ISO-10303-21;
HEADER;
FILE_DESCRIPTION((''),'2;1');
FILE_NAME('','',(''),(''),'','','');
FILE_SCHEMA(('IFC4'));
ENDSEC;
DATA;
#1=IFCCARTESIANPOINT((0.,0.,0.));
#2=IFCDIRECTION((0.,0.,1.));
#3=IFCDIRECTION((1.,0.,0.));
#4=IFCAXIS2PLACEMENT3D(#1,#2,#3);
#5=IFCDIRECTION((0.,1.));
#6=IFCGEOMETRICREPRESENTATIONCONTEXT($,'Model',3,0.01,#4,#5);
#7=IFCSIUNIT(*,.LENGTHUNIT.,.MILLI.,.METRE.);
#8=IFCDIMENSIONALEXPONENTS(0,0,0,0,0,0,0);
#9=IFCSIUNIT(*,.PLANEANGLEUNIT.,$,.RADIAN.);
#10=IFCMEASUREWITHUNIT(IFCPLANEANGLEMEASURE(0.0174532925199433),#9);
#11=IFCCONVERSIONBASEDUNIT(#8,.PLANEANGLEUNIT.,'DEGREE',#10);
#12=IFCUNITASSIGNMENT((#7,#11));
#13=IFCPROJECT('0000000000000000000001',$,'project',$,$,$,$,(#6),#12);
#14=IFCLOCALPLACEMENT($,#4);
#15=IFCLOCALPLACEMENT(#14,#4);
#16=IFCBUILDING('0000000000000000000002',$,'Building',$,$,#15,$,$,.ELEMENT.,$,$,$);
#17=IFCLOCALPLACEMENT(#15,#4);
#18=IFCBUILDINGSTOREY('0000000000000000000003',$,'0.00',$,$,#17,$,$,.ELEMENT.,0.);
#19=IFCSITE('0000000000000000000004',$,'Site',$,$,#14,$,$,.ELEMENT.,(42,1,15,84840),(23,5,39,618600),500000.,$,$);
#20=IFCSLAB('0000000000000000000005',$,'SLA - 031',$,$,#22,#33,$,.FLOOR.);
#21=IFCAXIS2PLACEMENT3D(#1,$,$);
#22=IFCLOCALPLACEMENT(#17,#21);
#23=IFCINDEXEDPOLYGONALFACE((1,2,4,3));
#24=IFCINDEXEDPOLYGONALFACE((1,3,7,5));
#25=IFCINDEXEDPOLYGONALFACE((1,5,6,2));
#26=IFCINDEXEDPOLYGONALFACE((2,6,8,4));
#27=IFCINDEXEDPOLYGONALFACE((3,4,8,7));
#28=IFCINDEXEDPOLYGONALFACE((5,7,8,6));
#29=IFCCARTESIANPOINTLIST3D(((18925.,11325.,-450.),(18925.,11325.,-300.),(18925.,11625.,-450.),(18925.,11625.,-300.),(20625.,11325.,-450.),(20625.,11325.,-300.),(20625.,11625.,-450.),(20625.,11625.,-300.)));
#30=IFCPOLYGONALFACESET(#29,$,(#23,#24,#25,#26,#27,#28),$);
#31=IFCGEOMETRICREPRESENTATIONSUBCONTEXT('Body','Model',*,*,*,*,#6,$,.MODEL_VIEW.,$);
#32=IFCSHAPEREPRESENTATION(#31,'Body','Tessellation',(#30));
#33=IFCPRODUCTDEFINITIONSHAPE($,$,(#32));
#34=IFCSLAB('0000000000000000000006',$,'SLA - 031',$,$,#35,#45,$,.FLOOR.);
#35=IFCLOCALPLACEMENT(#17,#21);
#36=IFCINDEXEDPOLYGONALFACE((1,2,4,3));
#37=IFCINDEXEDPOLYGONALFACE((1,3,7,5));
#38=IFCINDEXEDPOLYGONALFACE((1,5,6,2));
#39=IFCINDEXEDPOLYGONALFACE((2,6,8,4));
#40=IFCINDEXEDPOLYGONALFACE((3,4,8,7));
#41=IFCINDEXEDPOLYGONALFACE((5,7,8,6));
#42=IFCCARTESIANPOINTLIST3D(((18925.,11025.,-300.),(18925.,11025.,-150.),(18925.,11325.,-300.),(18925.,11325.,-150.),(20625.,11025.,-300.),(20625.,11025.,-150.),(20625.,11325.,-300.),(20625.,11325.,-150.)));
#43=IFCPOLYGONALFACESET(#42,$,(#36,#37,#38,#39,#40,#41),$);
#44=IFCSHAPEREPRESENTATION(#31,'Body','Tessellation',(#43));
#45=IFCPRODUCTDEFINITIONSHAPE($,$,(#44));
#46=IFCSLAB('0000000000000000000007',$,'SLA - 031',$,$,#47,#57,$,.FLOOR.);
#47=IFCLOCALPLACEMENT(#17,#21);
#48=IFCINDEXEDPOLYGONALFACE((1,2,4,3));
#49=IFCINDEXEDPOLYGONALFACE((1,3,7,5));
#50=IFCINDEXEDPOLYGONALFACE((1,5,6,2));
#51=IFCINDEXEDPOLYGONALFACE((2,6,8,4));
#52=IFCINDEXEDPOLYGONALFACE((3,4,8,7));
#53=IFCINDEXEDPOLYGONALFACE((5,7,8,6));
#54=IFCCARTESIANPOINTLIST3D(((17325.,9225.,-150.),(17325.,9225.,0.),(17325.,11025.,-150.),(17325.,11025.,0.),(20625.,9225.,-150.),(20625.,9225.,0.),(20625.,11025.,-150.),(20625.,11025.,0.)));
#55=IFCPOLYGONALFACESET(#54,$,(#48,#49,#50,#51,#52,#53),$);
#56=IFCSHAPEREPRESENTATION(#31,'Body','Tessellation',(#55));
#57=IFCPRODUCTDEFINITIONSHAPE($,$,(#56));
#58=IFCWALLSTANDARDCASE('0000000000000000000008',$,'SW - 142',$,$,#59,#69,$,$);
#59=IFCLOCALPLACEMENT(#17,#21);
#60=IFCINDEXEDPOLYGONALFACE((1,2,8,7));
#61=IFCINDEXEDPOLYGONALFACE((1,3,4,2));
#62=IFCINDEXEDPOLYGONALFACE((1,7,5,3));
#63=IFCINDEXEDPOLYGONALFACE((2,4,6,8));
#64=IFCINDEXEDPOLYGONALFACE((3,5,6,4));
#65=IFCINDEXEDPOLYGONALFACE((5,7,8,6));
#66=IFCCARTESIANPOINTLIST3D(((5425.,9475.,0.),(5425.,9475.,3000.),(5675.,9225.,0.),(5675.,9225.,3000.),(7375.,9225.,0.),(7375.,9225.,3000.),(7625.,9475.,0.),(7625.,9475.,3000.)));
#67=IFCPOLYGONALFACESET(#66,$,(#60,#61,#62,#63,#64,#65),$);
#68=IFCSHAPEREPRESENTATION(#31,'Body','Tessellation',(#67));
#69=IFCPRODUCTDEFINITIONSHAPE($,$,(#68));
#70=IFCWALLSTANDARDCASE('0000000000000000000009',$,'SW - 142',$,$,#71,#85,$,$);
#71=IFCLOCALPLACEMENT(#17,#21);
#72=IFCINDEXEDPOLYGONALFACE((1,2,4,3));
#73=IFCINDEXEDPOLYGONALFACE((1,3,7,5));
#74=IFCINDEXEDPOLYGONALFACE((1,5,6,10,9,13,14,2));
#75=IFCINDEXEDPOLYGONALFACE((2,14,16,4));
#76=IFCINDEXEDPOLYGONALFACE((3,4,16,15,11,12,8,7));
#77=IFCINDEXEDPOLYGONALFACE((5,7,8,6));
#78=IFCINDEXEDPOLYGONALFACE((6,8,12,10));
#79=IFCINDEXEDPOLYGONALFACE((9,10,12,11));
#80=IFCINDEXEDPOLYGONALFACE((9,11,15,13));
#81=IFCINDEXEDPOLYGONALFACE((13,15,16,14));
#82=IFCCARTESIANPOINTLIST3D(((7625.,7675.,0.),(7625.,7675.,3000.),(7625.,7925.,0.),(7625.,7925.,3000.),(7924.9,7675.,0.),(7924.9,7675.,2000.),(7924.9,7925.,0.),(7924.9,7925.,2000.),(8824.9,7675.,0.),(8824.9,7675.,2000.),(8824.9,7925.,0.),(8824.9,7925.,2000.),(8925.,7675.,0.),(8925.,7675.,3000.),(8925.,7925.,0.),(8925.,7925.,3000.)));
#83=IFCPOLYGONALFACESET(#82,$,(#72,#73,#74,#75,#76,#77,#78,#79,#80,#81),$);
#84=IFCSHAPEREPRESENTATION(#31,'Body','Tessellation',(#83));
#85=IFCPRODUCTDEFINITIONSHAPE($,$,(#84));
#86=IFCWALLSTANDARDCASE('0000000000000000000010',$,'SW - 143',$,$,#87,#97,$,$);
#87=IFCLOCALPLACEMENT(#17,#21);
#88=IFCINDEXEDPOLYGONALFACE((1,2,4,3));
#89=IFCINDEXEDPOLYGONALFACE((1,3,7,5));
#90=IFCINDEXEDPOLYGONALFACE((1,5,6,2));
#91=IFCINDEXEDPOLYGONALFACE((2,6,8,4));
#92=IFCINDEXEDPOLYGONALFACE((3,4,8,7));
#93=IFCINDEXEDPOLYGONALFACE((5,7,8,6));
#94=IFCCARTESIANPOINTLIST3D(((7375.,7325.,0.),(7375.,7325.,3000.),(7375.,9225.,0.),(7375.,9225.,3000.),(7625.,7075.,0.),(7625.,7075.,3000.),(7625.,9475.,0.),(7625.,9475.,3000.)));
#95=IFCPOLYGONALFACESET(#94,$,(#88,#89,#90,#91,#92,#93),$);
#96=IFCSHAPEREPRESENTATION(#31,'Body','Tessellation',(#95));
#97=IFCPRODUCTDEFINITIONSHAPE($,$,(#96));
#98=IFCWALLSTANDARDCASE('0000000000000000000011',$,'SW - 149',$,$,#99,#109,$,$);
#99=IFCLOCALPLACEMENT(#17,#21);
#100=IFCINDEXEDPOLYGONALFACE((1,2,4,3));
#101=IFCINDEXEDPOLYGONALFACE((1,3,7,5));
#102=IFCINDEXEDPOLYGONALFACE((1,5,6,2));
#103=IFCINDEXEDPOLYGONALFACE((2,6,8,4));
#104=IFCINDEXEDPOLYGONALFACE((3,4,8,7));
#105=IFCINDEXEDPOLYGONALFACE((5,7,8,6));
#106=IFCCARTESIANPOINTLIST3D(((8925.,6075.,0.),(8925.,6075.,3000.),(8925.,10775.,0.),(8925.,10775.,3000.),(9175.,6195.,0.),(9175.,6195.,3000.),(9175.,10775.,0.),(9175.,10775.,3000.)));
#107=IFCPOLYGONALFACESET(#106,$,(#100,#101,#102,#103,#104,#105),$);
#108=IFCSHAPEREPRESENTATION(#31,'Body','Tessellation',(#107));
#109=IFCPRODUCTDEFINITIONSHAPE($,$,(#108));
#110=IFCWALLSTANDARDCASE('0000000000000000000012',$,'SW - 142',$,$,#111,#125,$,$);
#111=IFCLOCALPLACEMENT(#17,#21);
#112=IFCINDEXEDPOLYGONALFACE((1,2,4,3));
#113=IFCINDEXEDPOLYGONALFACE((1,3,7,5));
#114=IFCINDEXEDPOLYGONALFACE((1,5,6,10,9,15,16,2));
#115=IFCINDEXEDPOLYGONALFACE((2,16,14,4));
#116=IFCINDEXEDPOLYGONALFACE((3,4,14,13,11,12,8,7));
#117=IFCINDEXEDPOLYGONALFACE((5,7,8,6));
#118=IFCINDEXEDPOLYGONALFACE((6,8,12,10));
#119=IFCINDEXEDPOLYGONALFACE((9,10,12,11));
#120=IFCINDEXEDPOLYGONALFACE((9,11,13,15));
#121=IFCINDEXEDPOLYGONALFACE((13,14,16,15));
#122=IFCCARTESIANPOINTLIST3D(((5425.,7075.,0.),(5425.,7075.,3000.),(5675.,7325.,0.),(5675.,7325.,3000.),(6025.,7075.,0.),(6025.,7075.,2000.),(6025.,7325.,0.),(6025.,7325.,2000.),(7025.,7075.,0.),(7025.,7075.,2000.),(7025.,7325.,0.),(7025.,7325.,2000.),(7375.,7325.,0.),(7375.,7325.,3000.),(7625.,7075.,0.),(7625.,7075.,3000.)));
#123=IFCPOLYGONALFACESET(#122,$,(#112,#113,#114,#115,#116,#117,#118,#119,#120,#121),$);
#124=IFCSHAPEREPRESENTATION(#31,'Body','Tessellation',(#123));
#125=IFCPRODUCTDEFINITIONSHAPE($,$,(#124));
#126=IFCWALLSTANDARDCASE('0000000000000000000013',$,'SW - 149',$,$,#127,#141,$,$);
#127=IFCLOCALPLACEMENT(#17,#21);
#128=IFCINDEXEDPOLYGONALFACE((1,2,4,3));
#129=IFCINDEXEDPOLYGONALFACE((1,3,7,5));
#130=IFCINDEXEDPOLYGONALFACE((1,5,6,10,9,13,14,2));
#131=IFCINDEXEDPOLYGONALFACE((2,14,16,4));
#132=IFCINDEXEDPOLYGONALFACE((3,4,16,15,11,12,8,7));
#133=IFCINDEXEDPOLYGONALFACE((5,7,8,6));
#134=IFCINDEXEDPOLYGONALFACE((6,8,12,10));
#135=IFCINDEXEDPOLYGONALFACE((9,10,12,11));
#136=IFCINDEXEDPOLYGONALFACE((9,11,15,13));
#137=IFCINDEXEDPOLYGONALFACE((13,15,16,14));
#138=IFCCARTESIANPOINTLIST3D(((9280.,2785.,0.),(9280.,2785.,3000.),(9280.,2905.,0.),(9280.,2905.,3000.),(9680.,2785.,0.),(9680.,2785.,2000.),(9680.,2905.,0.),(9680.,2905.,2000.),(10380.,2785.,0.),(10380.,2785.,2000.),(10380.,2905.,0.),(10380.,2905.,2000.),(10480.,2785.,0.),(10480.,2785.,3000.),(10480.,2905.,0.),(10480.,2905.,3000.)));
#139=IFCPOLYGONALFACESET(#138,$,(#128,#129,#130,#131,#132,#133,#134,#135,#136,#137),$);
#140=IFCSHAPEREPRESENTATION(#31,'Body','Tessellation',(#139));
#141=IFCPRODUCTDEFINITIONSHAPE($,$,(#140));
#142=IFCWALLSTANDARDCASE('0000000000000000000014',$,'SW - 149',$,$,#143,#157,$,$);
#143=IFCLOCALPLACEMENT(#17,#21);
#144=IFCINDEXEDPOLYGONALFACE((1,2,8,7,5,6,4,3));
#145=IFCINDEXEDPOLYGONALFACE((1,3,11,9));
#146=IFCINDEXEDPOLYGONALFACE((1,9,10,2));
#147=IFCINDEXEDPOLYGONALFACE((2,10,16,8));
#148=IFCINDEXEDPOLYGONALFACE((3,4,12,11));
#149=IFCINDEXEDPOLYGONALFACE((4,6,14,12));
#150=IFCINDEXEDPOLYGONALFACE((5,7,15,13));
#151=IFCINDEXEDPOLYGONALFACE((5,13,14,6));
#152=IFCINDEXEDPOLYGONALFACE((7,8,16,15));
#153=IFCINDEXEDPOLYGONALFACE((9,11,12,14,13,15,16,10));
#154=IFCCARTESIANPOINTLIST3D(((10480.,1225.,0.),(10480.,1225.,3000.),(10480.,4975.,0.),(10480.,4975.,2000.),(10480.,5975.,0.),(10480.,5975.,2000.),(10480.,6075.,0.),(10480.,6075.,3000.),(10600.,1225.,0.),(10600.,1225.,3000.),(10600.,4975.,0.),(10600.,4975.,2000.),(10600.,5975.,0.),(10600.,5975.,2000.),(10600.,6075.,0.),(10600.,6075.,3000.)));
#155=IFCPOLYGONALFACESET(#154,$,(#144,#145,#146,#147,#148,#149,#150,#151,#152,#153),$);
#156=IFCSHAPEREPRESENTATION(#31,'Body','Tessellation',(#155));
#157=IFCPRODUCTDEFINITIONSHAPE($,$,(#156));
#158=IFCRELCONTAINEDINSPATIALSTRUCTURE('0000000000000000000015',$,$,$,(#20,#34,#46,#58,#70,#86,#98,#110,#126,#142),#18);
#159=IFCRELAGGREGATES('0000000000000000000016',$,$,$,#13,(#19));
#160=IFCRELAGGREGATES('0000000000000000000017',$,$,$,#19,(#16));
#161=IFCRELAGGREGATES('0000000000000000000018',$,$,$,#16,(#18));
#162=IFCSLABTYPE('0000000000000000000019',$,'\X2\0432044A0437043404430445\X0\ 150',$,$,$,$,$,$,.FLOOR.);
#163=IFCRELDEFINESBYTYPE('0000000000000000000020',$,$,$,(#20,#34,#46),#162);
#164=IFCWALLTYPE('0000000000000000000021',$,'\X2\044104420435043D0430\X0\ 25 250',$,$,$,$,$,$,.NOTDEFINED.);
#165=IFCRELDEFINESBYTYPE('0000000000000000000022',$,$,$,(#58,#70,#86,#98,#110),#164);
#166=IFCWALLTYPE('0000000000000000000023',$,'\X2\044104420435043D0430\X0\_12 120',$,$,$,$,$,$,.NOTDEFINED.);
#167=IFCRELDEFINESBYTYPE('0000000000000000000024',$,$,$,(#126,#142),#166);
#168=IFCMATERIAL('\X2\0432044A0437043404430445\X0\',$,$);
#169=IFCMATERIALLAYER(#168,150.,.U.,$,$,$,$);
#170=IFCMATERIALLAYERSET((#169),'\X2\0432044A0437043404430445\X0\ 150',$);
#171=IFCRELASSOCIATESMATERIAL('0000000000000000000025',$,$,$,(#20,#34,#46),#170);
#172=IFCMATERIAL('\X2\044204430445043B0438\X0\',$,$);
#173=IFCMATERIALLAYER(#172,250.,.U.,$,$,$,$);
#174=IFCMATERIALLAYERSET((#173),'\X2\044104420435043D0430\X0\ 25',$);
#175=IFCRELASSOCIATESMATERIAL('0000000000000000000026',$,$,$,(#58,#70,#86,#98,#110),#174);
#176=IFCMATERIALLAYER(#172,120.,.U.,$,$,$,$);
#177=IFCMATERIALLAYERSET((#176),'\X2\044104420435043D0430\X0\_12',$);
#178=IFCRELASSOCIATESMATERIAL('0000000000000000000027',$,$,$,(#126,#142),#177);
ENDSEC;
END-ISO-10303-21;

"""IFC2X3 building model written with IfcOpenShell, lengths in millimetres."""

from ifc_helpers import new_model, entity, si_unit, converted_unit, direction, frame, origin_with_axes, origin_2d_with_axis, place, context, subcontext, project, spatial, polyline, rectangle, outline, extrude, material, layer, layer_set, layer_usage, type_object, element, save


model = new_model("IFC2X3")

# Units and contexts
model_context = context("Model", 3, precision=0.01, world=origin_with_axes(), true_north=direction((0.0, 1.0)))
body_context = subcontext(model_context, "Body", "Model", "MODEL_VIEW")
ifc_project = project(units=[si_unit("LENGTHUNIT", "METRE", prefix="MILLI"), converted_unit("PLANEANGLEUNIT", "DEGREE", entity("IfcPlaneAngleMeasure", 0.0174532925199433), si_unit("PLANEANGLEUNIT", "RADIAN"), dimensions=[0, 0, 0, 0, 0, 0, 0])], contexts=[model_context])

# Site, building, storey
site_placement = place(None, origin_with_axes())
site = spatial("IfcSite", under=ifc_project, at=site_placement, Name="Site", CompositionType="ELEMENT", RefLatitude=(42, 1, 15, 84840), RefLongitude=(23, 5, 39, 618600), RefElevation=500000.0)
building_placement = place(site_placement, origin_with_axes())
building = spatial("IfcBuilding", under=site, at=building_placement, Name="Building", CompositionType="ELEMENT")
storey_placement = place(building_placement, origin_with_axes())
storey = spatial("IfcBuildingStorey", under=building, at=storey_placement, Name="0.00", CompositionType="ELEMENT", Elevation=0.0)

# Slabs
ifc_material_1 = material(Name="въздух")
ifc_layer_1 = layer(ifc_material_1, 150.0, ventilated="UNKNOWN")
ifc_layer_set_1 = layer_set([ifc_layer_1], Name="въздух 150")
ifc_layer_usage_1 = layer_usage(ifc_layer_set_1, "AXIS3", "NEGATIVE", 150.0)
slab_type = type_object("IfcSlabType", Name="въздух 150", PredefinedType="FLOOR")
slab_1_placement = place(storey_placement, frame((18925.0, 11625.0, -300.0), z_axis=(0.0, 0.0, 1.0), x_axis=(1.0, 0.0, 0.0)))
element("IfcSlab", 1, at=slab_1_placement, inside=storey, type_object=slab_type, material=ifc_layer_usage_1, Name="SLA - 031", PredefinedType="FLOOR", context=body_context, shape_type="SweptSolid", body=[
    extrude(outline(polyline([(0.0, 0.0), (0.0, -300.0), (1700.0, -300.0), (1700.0, 0.0), (0.0, 0.0)])), frame((0.0, 0.0, -150.0), z_axis=(0.0, 0.0, 1.0), x_axis=(1.0, 0.0, 0.0)), (0.0, 0.0, 1.0), 150.0),
])
ifc_layer_usage_2 = layer_usage(ifc_layer_set_1, "AXIS3", "NEGATIVE", 150.0)
slab_2_placement = place(storey_placement, frame((18925.0, 11325.0, -150.0), z_axis=(0.0, 0.0, 1.0), x_axis=(1.0, 0.0, 0.0)))
element("IfcSlab", 2, at=slab_2_placement, inside=storey, type_object=slab_type, material=ifc_layer_usage_2, Name="SLA - 031", PredefinedType="FLOOR", context=body_context, shape_type="SweptSolid", body=[
    extrude(outline(polyline([(0.0, 0.0), (0.0, -300.0), (1700.0, -300.0), (1700.0, 0.0), (0.0, 0.0)])), frame((0.0, 0.0, -150.0), z_axis=(0.0, 0.0, 1.0), x_axis=(1.0, 0.0, 0.0)), (0.0, 0.0, 1.0), 150.0),
])
ifc_layer_usage_3 = layer_usage(ifc_layer_set_1, "AXIS3", "NEGATIVE", 150.0)
slab_3_placement = place(storey_placement, frame((17325.0, 11025.0, 0.0), z_axis=(0.0, 0.0, 1.0), x_axis=(1.0, 0.0, 0.0)))
element("IfcSlab", 3, at=slab_3_placement, inside=storey, type_object=slab_type, material=ifc_layer_usage_3, Name="SLA - 031", PredefinedType="FLOOR", context=body_context, shape_type="SweptSolid", body=[
    extrude(outline(polyline([(0.0, 0.0), (0.0, -1800.0), (3300.0, -1800.0), (3300.0, 0.0), (0.0, 0.0)])), frame((0.0, 0.0, -150.0), z_axis=(0.0, 0.0, 1.0), x_axis=(1.0, 0.0, 0.0)), (0.0, 0.0, 1.0), 150.0),
])

# Shared definitions
ifc_material_2 = material(Name="тухли")

# Wall
ifc_layer_2 = layer(ifc_material_2, 250.0, ventilated="UNKNOWN")
ifc_layer_set_2 = layer_set([ifc_layer_2], Name="стена 25")
ifc_layer_usage_4 = layer_usage(ifc_layer_set_2, "AXIS2", "POSITIVE", 0.0)
wall_type_1 = type_object("IfcWallType", Name="стена 25 250", PredefinedType="NOTDEFINED")
wall_1_placement = place(storey_placement, frame((7625.0, 9475.0, 0.0), z_axis=(0.0, 0.0, 1.0), x_axis=(-1.0, 0.0, 0.0)))
element("IfcWallStandardCase", 4, at=wall_1_placement, inside=storey, type_object=wall_type_1, material=ifc_layer_usage_4, Name="SW - 142", context=body_context, shape_type="SweptSolid", body=[
    extrude(outline(polyline([(0.0, 0.0), (2200.0, 0.0), (1950.0, 250.0), (250.0, 250.0), (0.0, 0.0)])), origin_with_axes(), (0.0, 0.0, 1.0), 3000.0),
])

# Wall, opening
ifc_layer_usage_5 = layer_usage(ifc_layer_set_2, "AXIS2", "NEGATIVE", 0.0)
wall_2_placement = place(storey_placement, frame((8925.0, 7675.0, 0.0), z_axis=(0.0, 0.0, 1.0), x_axis=(-1.0, 0.0, 0.0)))
wall_2 = element("IfcWallStandardCase", 5, at=wall_2_placement, inside=storey, type_object=wall_type_1, material=ifc_layer_usage_5, Name="SW - 142", context=body_context, shape_type="SweptSolid", body=[
    extrude(outline(polyline([(0.0, -250.0), (1300.0, -250.0), (1300.0, 0.0), (0.0, 0.0), (0.0, -250.0)])), origin_with_axes(), (0.0, 0.0, 1.0), 3000.0),
])
opening_1_placement = place(wall_2_placement, frame((550.1, 0.0, 0.0), z_axis=(0.0, 0.0, 1.0), x_axis=(1.0, 0.0, 0.0)))
element("IfcOpeningElement", 6, at=opening_1_placement, cuts=wall_2, context=body_context, shape_type="SweptSolid", body=[
    extrude(rectangle(XDim=900.0, YDim=2000.0, at=origin_2d_with_axis()), frame((0.0, 250.0, 1000.0), z_axis=(0.0, -1.0, 0.0), x_axis=(-1.0, 0.0, 0.0)), (0.0, 0.0, 1.0), 750.0),
])

# Walls
ifc_layer_usage_6 = layer_usage(ifc_layer_set_2, "AXIS2", "NEGATIVE", 0.0)
wall_3_placement = place(storey_placement, frame((7625.0, 9475.0, 0.0), z_axis=(0.0, 0.0, 1.0), x_axis=(0.0, -1.0, 0.0)))
element("IfcWallStandardCase", 7, at=wall_3_placement, inside=storey, type_object=wall_type_1, material=ifc_layer_usage_6, Name="SW - 143", context=body_context, shape_type="SweptSolid", body=[
    extrude(outline(polyline([(250.0, -250.0), (2150.0, -250.0), (2400.0, 0.0), (0.0, 0.0), (250.0, -250.0)])), origin_with_axes(), (0.0, 0.0, 1.0), 3000.0),
])
ifc_layer_usage_7 = layer_usage(ifc_layer_set_2, "AXIS2", "NEGATIVE", 0.0)
wall_4_placement = place(storey_placement, frame((8925.0, 6075.0, 0.0), z_axis=(0.0, 0.0, 1.0), x_axis=(0.0, 1.0, 0.0)))
element("IfcWallStandardCase", 8, at=wall_4_placement, inside=storey, type_object=wall_type_1, material=ifc_layer_usage_7, Name="SW - 149", context=body_context, shape_type="SweptSolid", body=[
    extrude(outline(polyline([(120.0, -250.0), (4700.0, -250.0), (4700.0, 0.0), (0.0, 0.0), (120.0, -250.0)])), origin_with_axes(), (0.0, 0.0, 1.0), 3000.0),
])

# Walls, openings
ifc_layer_usage_8 = layer_usage(ifc_layer_set_2, "AXIS2", "NEGATIVE", 0.0)
wall_5_placement = place(storey_placement, frame((7625.0, 7075.0, 0.0), z_axis=(0.0, 0.0, 1.0), x_axis=(-1.0, 0.0, 0.0)))
wall_5 = element("IfcWallStandardCase", 9, at=wall_5_placement, inside=storey, type_object=wall_type_1, material=ifc_layer_usage_8, Name="SW - 142", context=body_context, shape_type="SweptSolid", body=[
    extrude(outline(polyline([(250.0, -250.0), (1950.0, -250.0), (2200.0, 0.0), (0.0, 0.0), (250.0, -250.0)])), origin_with_axes(), (0.0, 0.0, 1.0), 3000.0),
])
opening_2_placement = place(wall_5_placement, frame((1100.0, 0.0, 0.0), z_axis=(0.0, 0.0, 1.0), x_axis=(1.0, 0.0, 0.0)))
element("IfcOpeningElement", 10, at=opening_2_placement, cuts=wall_5, context=body_context, shape_type="SweptSolid", body=[
    extrude(rectangle(XDim=1000.0, YDim=2000.0, at=origin_2d_with_axis()), frame((0.0, -250.0, 1000.0), z_axis=(0.0, 1.0, 0.0), x_axis=(-1.0, 0.0, 0.0)), (0.0, 0.0, 1.0), 750.0),
])
ifc_layer_3 = layer(ifc_material_2, 120.0, ventilated="UNKNOWN")
ifc_layer_set_3 = layer_set([ifc_layer_3], Name="стена_12")
wall_type_2 = type_object("IfcWallType", Name="стена_12 120", PredefinedType="NOTDEFINED")
ifc_layer_usage_9 = layer_usage(ifc_layer_set_3, "AXIS2", "NEGATIVE", 0.0)
wall_6_placement = place(storey_placement, frame((9280.0, 2905.0, 0.0), z_axis=(0.0, 0.0, 1.0), x_axis=(1.0, 0.0, 0.0)))
wall_6 = element("IfcWallStandardCase", 11, at=wall_6_placement, inside=storey, type_object=wall_type_2, material=ifc_layer_usage_9, Name="SW - 149", context=body_context, shape_type="SweptSolid", body=[
    extrude(outline(polyline([(0.0, -120.0), (1200.0, -120.0), (1200.0, 0.0), (0.0, 0.0), (0.0, -120.0)])), origin_with_axes(), (0.0, 0.0, 1.0), 3000.0),
])
opening_3_placement = place(wall_6_placement, frame((750.0, 0.0, 0.0), z_axis=(0.0, 0.0, 1.0), x_axis=(1.0, 0.0, 0.0)))
element("IfcOpeningElement", 12, at=opening_3_placement, cuts=wall_6, context=body_context, shape_type="SweptSolid", body=[
    extrude(rectangle(XDim=700.0, YDim=2000.0, at=origin_2d_with_axis()), frame((0.0, 120.0, 1000.0), z_axis=(0.0, 1.0, 0.0), x_axis=(1.0, 0.0, 0.0)), (0.0, 0.0, -1.0), 360.0),
])

# Wall, opening
ifc_layer_usage_10 = layer_usage(ifc_layer_set_3, "AXIS2", "NEGATIVE", 0.0)
wall_7_placement = place(storey_placement, frame((10600.0, 6075.0, 0.0), z_axis=(0.0, 0.0, 1.0), x_axis=(0.0, -1.0, 0.0)))
wall_7 = element("IfcWallStandardCase", 13, at=wall_7_placement, inside=storey, type_object=wall_type_2, material=ifc_layer_usage_10, Name="SW - 149", context=body_context, shape_type="SweptSolid", body=[
    extrude(outline(polyline([(0.0, -120.0), (4850.0, -120.0), (4850.0, 0.0), (0.0, 0.0), (0.0, -120.0)])), origin_with_axes(), (0.0, 0.0, 1.0), 3000.0),
])
opening_4_placement = place(wall_7_placement, frame((600.0, 0.0, 0.0), z_axis=(0.0, 0.0, 1.0), x_axis=(1.0, 0.0, 0.0)))
element("IfcOpeningElement", 14, at=opening_4_placement, cuts=wall_7, context=body_context, shape_type="SweptSolid", body=[
    extrude(rectangle(XDim=1000.0, YDim=2000.0, at=origin_2d_with_axis()), frame((0.0, 120.0, 1000.0), z_axis=(0.0, -1.0, 0.0), x_axis=(-1.0, 0.0, 0.0)), (0.0, 0.0, 1.0), 360.0),
])

save(model, "model.ifc")
